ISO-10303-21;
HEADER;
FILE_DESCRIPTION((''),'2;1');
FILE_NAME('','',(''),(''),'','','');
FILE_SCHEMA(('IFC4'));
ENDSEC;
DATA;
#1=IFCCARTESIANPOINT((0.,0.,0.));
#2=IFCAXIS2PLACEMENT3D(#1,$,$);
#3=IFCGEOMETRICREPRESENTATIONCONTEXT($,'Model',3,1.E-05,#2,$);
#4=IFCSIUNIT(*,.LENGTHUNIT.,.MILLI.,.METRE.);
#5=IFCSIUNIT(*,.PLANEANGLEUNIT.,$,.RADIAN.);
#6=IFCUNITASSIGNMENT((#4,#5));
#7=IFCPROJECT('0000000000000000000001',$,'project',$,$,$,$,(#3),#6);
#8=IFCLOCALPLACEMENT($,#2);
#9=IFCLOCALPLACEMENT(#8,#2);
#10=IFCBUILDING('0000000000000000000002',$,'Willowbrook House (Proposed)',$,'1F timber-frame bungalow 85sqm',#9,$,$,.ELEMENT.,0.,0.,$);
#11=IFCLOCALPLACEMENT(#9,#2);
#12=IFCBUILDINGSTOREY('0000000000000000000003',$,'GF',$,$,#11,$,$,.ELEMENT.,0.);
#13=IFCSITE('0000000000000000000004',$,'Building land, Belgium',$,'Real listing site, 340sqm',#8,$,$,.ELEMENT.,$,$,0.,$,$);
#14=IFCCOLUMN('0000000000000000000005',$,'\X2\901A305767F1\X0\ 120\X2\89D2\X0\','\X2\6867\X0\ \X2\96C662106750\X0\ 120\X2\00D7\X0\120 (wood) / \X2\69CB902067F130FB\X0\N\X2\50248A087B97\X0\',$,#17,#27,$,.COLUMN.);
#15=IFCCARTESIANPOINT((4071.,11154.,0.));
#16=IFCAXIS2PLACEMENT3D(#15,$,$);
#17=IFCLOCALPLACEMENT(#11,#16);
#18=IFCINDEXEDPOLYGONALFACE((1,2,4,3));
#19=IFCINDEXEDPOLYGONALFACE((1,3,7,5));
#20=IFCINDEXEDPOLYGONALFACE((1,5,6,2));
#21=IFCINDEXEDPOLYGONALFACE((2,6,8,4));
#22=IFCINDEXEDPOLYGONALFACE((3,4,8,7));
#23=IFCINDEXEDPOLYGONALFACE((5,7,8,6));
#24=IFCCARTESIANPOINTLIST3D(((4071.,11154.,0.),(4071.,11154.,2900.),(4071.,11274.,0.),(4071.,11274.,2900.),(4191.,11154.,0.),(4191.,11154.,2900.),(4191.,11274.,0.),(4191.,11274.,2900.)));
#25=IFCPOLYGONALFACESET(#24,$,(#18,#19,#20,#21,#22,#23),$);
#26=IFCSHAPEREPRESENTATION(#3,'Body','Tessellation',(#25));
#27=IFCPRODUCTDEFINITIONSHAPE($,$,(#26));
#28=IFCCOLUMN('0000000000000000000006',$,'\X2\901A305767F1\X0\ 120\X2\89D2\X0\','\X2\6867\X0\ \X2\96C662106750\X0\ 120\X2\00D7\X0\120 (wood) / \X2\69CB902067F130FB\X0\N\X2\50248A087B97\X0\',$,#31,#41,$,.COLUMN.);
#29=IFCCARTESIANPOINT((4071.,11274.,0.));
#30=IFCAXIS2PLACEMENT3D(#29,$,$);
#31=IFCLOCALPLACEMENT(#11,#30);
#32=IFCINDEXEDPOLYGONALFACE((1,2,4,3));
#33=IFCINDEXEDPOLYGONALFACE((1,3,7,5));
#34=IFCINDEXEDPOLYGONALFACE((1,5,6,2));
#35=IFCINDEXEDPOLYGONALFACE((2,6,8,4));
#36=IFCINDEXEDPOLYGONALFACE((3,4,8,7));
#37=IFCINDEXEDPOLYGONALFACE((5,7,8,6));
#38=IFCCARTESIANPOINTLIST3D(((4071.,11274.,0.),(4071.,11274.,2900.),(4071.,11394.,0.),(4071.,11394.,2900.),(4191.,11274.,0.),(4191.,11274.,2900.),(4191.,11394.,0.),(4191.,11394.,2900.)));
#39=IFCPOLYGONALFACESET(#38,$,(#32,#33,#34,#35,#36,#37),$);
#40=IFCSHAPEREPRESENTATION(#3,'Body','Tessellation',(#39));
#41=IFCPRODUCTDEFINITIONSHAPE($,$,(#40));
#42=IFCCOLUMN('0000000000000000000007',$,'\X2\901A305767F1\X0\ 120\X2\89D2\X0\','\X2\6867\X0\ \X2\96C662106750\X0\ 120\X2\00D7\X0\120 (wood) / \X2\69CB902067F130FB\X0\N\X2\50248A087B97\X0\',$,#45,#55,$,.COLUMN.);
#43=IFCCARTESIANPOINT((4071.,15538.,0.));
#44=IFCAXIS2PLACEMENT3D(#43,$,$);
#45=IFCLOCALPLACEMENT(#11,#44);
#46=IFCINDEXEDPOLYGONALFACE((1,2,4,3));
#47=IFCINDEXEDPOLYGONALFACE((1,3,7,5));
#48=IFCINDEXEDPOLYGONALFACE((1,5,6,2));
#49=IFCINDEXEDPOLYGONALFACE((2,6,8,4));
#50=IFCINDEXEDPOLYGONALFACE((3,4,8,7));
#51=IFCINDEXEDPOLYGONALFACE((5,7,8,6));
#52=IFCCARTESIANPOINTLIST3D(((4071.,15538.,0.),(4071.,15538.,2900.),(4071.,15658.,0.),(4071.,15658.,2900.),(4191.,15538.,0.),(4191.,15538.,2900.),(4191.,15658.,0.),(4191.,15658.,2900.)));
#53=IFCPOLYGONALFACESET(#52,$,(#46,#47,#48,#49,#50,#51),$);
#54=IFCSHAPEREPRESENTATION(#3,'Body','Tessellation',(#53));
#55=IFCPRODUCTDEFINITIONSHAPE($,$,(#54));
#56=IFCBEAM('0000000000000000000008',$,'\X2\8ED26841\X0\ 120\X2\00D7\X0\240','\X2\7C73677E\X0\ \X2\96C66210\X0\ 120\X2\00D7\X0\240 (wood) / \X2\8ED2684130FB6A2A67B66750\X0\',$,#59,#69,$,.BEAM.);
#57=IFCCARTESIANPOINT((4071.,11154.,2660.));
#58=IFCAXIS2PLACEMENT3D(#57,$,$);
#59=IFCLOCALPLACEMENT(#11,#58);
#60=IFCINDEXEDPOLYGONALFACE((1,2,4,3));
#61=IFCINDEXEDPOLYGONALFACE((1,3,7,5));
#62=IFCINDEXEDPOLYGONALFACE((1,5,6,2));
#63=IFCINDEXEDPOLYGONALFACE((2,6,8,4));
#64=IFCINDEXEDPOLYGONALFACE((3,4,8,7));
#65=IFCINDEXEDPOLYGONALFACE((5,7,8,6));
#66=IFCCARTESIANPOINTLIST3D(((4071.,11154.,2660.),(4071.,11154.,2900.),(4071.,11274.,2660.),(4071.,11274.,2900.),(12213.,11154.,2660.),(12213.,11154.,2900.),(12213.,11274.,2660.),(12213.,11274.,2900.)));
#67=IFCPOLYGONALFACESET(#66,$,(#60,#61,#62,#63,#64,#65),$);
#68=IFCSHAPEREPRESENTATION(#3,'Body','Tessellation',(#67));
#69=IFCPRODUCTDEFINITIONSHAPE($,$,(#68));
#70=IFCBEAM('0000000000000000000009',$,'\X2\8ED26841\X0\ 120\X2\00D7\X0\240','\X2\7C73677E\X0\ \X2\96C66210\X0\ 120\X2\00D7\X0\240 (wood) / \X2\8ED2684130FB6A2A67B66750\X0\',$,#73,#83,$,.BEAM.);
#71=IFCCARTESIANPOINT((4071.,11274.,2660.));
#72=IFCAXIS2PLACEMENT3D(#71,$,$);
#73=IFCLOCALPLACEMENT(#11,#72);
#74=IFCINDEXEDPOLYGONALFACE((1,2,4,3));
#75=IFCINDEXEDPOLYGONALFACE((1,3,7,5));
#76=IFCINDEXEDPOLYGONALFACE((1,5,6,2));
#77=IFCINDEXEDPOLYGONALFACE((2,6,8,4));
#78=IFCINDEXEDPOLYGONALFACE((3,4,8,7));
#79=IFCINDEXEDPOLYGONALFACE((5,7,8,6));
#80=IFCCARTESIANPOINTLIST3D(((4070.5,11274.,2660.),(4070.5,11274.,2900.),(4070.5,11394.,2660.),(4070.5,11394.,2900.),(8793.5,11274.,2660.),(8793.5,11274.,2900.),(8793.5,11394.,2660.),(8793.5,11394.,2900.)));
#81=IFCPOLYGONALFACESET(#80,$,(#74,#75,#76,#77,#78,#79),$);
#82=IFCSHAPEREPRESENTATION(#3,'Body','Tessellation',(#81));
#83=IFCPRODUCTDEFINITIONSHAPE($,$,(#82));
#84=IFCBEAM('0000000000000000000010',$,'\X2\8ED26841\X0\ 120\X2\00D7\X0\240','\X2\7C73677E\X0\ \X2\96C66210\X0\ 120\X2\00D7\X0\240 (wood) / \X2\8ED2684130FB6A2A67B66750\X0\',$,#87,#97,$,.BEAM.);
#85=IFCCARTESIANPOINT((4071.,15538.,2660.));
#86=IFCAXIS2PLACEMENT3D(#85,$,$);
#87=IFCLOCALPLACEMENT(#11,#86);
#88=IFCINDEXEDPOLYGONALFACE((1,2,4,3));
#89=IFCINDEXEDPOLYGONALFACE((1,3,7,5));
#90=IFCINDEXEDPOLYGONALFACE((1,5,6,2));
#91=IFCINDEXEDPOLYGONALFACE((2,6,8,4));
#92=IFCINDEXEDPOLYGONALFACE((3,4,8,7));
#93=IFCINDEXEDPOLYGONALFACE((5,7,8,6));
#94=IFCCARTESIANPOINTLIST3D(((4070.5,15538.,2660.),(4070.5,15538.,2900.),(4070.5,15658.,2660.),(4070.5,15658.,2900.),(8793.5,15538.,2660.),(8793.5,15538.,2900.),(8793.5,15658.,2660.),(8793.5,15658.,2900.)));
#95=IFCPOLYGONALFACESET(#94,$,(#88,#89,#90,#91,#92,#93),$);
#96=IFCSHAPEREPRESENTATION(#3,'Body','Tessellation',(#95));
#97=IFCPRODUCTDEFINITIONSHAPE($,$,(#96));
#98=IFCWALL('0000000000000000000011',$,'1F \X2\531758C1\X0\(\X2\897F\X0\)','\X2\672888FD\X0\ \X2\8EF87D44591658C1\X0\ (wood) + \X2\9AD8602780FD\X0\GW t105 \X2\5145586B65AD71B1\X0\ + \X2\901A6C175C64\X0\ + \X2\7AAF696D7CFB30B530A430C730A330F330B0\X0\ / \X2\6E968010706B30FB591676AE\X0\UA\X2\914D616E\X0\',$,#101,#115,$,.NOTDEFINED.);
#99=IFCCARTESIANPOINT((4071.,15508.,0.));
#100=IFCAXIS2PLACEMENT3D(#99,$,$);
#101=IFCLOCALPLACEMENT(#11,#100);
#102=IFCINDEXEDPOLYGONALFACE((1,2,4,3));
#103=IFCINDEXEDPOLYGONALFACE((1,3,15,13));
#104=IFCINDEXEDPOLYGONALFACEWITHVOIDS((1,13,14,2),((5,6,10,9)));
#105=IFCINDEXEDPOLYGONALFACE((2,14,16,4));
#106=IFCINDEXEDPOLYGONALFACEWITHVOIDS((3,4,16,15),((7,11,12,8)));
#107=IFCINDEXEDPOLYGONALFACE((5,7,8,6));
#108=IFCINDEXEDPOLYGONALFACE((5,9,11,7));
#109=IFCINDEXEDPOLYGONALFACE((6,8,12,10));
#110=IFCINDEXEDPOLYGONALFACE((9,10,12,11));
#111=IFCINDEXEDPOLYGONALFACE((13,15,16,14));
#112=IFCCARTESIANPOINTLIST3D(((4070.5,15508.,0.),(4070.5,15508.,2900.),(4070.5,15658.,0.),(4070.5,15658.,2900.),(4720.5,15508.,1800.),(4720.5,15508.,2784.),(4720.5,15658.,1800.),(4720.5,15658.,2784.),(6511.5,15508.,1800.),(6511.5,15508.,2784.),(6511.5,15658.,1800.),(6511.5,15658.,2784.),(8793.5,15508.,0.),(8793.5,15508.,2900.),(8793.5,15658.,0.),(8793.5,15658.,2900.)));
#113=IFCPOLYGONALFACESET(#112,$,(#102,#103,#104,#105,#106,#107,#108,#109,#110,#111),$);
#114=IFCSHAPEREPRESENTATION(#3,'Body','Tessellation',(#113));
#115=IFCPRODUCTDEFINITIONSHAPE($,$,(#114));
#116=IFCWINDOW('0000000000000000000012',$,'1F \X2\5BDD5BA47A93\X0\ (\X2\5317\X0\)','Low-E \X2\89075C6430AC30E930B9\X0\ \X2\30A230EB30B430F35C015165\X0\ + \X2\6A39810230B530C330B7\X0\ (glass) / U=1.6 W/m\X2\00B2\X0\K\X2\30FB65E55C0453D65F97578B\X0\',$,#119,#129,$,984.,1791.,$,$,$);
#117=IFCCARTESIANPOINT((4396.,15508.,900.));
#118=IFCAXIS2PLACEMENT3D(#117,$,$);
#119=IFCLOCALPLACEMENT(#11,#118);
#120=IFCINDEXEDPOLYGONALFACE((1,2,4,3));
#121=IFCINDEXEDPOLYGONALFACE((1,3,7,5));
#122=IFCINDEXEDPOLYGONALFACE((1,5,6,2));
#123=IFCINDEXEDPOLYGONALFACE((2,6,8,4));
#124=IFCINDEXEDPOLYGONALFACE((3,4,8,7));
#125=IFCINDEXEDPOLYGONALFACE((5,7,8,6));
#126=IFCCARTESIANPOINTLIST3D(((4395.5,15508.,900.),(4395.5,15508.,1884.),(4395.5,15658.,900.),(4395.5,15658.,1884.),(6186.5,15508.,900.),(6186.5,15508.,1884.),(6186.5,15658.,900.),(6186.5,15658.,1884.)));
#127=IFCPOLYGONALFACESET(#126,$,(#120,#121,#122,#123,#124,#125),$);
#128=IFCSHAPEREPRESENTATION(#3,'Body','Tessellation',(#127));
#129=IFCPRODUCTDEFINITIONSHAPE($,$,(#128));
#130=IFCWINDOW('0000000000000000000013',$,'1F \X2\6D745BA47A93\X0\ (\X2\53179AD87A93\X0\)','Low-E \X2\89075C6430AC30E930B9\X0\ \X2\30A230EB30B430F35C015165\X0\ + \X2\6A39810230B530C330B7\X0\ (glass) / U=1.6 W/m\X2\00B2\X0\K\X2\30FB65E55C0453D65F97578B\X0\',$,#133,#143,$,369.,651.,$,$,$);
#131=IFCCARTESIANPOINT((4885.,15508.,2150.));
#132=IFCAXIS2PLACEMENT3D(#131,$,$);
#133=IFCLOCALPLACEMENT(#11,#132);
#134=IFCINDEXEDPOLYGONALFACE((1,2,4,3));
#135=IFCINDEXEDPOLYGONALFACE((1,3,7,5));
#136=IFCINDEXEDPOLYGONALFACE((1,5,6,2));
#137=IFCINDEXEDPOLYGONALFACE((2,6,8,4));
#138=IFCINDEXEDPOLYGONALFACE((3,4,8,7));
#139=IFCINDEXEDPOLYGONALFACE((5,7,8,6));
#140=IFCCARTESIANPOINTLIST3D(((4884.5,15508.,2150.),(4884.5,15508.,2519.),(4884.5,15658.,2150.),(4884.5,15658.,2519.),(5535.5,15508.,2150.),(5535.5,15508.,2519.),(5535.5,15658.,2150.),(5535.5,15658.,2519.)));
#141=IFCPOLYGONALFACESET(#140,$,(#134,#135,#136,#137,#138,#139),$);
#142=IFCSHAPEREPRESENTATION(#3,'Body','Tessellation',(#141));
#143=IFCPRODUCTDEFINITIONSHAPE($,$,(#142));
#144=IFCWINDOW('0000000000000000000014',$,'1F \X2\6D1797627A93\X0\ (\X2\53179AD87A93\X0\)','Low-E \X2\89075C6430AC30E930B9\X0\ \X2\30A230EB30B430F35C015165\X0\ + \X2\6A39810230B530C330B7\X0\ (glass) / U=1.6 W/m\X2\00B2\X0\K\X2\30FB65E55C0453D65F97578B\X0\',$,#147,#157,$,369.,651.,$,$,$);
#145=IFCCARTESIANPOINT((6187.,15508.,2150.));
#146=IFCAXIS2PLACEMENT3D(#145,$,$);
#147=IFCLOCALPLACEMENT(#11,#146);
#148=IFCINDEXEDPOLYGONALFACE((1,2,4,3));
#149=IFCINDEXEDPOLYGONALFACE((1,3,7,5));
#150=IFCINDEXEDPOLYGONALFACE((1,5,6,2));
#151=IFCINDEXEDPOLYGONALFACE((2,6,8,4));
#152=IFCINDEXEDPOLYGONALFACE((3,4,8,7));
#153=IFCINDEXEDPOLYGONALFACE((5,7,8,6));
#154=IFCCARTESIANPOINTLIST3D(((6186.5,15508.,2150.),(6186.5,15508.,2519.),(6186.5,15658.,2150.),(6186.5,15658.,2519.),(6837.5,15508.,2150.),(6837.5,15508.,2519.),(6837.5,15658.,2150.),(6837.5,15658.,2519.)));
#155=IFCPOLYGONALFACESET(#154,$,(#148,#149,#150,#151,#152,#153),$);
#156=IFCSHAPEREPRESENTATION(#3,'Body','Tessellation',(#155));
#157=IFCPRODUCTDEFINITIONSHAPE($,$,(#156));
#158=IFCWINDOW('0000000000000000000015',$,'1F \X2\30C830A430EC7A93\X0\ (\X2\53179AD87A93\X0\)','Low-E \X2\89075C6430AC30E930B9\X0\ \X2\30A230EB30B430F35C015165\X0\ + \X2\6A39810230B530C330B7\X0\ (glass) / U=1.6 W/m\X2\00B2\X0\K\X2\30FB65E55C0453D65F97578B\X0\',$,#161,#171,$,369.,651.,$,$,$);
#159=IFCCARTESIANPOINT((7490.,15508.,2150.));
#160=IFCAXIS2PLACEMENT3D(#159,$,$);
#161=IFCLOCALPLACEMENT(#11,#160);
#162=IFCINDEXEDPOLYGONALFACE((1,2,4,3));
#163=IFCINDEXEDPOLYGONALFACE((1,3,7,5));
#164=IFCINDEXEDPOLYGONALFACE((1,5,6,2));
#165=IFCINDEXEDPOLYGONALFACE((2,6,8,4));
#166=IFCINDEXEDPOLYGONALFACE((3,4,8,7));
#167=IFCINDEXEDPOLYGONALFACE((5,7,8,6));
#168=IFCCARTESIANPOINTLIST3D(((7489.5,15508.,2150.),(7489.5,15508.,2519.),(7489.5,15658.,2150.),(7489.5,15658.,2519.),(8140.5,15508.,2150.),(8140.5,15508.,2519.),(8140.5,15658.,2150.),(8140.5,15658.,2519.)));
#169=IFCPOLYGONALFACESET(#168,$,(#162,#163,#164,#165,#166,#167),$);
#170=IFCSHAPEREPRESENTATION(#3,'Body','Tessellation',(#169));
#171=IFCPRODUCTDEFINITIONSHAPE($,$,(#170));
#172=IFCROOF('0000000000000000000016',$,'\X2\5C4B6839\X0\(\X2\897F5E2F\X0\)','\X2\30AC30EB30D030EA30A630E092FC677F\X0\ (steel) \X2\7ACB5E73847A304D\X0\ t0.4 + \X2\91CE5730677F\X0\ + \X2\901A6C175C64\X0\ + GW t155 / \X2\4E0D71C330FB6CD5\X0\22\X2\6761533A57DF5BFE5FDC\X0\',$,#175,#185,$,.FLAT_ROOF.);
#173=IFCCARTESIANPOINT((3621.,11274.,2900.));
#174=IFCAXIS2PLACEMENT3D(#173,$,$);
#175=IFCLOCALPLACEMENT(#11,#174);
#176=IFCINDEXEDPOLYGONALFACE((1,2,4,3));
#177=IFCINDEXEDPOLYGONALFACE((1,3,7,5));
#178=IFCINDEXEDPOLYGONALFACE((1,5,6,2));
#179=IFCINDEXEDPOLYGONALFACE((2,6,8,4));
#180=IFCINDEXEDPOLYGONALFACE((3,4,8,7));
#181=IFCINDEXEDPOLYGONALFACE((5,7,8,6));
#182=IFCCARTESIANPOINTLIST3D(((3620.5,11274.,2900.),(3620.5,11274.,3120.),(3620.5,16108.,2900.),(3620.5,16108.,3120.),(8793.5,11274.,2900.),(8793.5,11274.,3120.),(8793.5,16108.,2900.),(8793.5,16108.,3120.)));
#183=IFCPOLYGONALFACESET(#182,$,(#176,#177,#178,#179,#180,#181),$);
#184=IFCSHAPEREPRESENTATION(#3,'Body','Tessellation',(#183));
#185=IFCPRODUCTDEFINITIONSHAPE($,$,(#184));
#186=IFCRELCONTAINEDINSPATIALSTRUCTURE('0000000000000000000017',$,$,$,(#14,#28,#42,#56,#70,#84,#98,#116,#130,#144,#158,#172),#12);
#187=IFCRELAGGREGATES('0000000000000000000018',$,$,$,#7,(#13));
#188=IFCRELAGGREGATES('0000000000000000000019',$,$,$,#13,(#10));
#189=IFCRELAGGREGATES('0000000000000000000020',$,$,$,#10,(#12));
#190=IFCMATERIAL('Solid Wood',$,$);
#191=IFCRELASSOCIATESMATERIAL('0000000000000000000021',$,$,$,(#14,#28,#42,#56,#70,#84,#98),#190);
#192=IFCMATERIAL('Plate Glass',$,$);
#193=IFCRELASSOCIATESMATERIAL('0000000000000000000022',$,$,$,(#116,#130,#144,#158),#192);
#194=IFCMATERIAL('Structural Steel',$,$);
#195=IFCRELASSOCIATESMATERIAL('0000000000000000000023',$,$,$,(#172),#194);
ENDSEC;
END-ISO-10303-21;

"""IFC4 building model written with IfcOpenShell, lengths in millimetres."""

from ifc_helpers import new_model, si_unit, frame, frame_2d, origin, place, context, project, spatial, rectangle, extrude, material, element, fill, save


model = new_model("IFC4")

# Units and contexts
model_context = context("Model", 3, precision=1e-05, world=origin())
ifc_project = project(units=[si_unit("LENGTHUNIT", "METRE", prefix="MILLI"), si_unit("PLANEANGLEUNIT", "RADIAN")], contexts=[model_context])

# Site, building, storey
site_placement = place(None, origin())
site = spatial("IfcSite", under=ifc_project, at=site_placement, Name="Building land, Belgium", ObjectType="Real listing site, 340sqm", CompositionType="ELEMENT", RefElevation=0.0)
building_placement = place(site_placement, origin())
building = spatial("IfcBuilding", under=site, at=building_placement, Name="Willowbrook House (Proposed)", ObjectType="1F timber-frame bungalow 85sqm", CompositionType="ELEMENT", ElevationOfRefHeight=0.0, ElevationOfTerrain=0.0)
storey_placement = place(building_placement, origin())
storey = spatial("IfcBuildingStorey", under=building, at=storey_placement, Name="GF", CompositionType="ELEMENT", Elevation=0.0)

# Columns
ifc_material_1 = material(Name="Solid Wood")
column_1_placement = place(storey_placement, frame((4071.0, 11154.0, 0.0)))
element("IfcColumn", 1, at=column_1_placement, inside=storey, material=ifc_material_1, Name="通し柱 120角", Description="桧 集成材 120×120 (wood) / 構造柱・N値計算", PredefinedType="COLUMN", context=model_context, shape_type="SweptSolid", body=[
    extrude(rectangle(XDim=120.0, YDim=120.0, at=frame_2d((60.0, 60.0))), frame((4071.0, 11154.0, 0.0)), (0.0, 0.0, 1.0), 2900.0),
])
column_2_placement = place(storey_placement, frame((4071.0, 11274.0, 0.0)))
element("IfcColumn", 2, at=column_2_placement, inside=storey, material=ifc_material_1, Name="通し柱 120角", Description="桧 集成材 120×120 (wood) / 構造柱・N値計算", PredefinedType="COLUMN", context=model_context, shape_type="SweptSolid", body=[
    extrude(rectangle(XDim=120.0, YDim=120.0, at=frame_2d((60.0, 60.0))), frame((4071.0, 11274.0, 0.0)), (0.0, 0.0, 1.0), 2900.0),
])
column_3_placement = place(storey_placement, frame((4071.0, 15538.0, 0.0)))
element("IfcColumn", 3, at=column_3_placement, inside=storey, material=ifc_material_1, Name="通し柱 120角", Description="桧 集成材 120×120 (wood) / 構造柱・N値計算", PredefinedType="COLUMN", context=model_context, shape_type="SweptSolid", body=[
    extrude(rectangle(XDim=120.0, YDim=120.0, at=frame_2d((60.0, 60.0))), frame((4071.0, 15538.0, 0.0)), (0.0, 0.0, 1.0), 2900.0),
])

# Beams
beam_1_placement = place(storey_placement, frame((4071.0, 11154.0, 2660.0)))
element("IfcBeam", 4, at=beam_1_placement, inside=storey, material=ifc_material_1, Name="軒桁 120×240", Description="米松 集成 120×240 (wood) / 軒桁・横架材", PredefinedType="BEAM", context=model_context, shape_type="SweptSolid", body=[
    extrude(rectangle(XDim=8142.0, YDim=120.0, at=frame_2d((4071.0, 60.0))), frame((4071.0, 11154.0, 2660.0)), (0.0, 0.0, 1.0), 240.0),
])
beam_2_placement = place(storey_placement, frame((4071.0, 11274.0, 2660.0)))
element("IfcBeam", 5, at=beam_2_placement, inside=storey, material=ifc_material_1, Name="軒桁 120×240", Description="米松 集成 120×240 (wood) / 軒桁・横架材", PredefinedType="BEAM", context=model_context, shape_type="SweptSolid", body=[
    extrude(rectangle(XDim=4723.0, YDim=120.0, at=frame_2d((2361.0, 60.0))), frame((4071.0, 11274.0, 2660.0)), (0.0, 0.0, 1.0), 240.0),
])
beam_3_placement = place(storey_placement, frame((4071.0, 15538.0, 2660.0)))
element("IfcBeam", 6, at=beam_3_placement, inside=storey, material=ifc_material_1, Name="軒桁 120×240", Description="米松 集成 120×240 (wood) / 軒桁・横架材", PredefinedType="BEAM", context=model_context, shape_type="SweptSolid", body=[
    extrude(rectangle(XDim=4723.0, YDim=120.0, at=frame_2d((2361.0, 60.0))), frame((4071.0, 15538.0, 2660.0)), (0.0, 0.0, 1.0), 240.0),
])

# Wall, openings, windows
wall_1_placement = place(storey_placement, frame((4071.0, 15508.0, 0.0)))
wall_1 = element("IfcWall", 7, at=wall_1_placement, inside=storey, material=ifc_material_1, Name="1F 北壁(西)", Description="木製 軸組外壁 (wood) + 高性能GW t105 充填断熱 + 通気層 + 窯業系サイディング / 準耐火・外皮UA配慮", PredefinedType="NOTDEFINED", context=model_context, shape_type="SweptSolid", body=[
    extrude(rectangle(XDim=4723.0, YDim=150.0, at=frame_2d((2361.0, 75.0))), frame((4071.0, 15508.0, 0.0)), (0.0, 0.0, 1.0), 2900.0),
])
opening_1_placement = place(storey_placement, frame((4396.0, 15508.0, 900.0)))
opening_1 = element("IfcOpeningElement", 8, at=opening_1_placement, cuts=wall_1, PredefinedType="NOTDEFINED", context=model_context, shape_type="SweptSolid", body=[
    extrude(rectangle(XDim=1791.0, YDim=150.0, at=frame_2d((895.0, 75.0))), frame((4396.0, 15508.0, 900.0)), (0.0, 0.0, 1.0), 984.0),
])
opening_2_placement = place(storey_placement, frame((4885.0, 15508.0, 2150.0)))
opening_2 = element("IfcOpeningElement", 9, at=opening_2_placement, cuts=wall_1, PredefinedType="NOTDEFINED", context=model_context, shape_type="SweptSolid", body=[
    extrude(rectangle(XDim=651.0, YDim=150.0, at=frame_2d((325.0, 75.0))), frame((4885.0, 15508.0, 2150.0)), (0.0, 0.0, 1.0), 369.0),
])
opening_3_placement = place(storey_placement, frame((6187.0, 15508.0, 2150.0)))
opening_3 = element("IfcOpeningElement", 10, at=opening_3_placement, cuts=wall_1, PredefinedType="NOTDEFINED", context=model_context, shape_type="SweptSolid", body=[
    extrude(rectangle(XDim=651.0, YDim=150.0, at=frame_2d((325.0, 75.0))), frame((6187.0, 15508.0, 2150.0)), (0.0, 0.0, 1.0), 369.0),
])
opening_4_placement = place(storey_placement, frame((7490.0, 15508.0, 2150.0)))
opening_4 = element("IfcOpeningElement", 11, at=opening_4_placement, cuts=wall_1, PredefinedType="NOTDEFINED", context=model_context, shape_type="SweptSolid", body=[
    extrude(rectangle(XDim=651.0, YDim=150.0, at=frame_2d((325.0, 75.0))), frame((7490.0, 15508.0, 2150.0)), (0.0, 0.0, 1.0), 369.0),
])
ifc_material_2 = material(Name="Plate Glass")
window_1_placement = place(storey_placement, frame((4396.0, 15508.0, 900.0)))
window_1 = element("IfcWindow", 12, at=window_1_placement, inside=storey, material=ifc_material_2, Name="1F 寝室窓 (北)", Description="Low-E 複層ガラス アルゴン封入 + 樹脂サッシ (glass) / U=1.6 W/m²K・日射取得型", OverallHeight=984.0, OverallWidth=1791.0, context=model_context, shape_type="SweptSolid", body=[
    extrude(rectangle(XDim=1791.0, YDim=150.0, at=frame_2d((895.0, 75.0))), frame((4396.0, 15508.0, 900.0)), (0.0, 0.0, 1.0), 984.0),
])
fill(opening_1, window_1)
window_2_placement = place(storey_placement, frame((4885.0, 15508.0, 2150.0)))
window_2 = element("IfcWindow", 13, at=window_2_placement, inside=storey, material=ifc_material_2, Name="1F 浴室窓 (北高窓)", Description="Low-E 複層ガラス アルゴン封入 + 樹脂サッシ (glass) / U=1.6 W/m²K・日射取得型", OverallHeight=369.0, OverallWidth=651.0, context=model_context, shape_type="SweptSolid", body=[
    extrude(rectangle(XDim=651.0, YDim=150.0, at=frame_2d((325.0, 75.0))), frame((4885.0, 15508.0, 2150.0)), (0.0, 0.0, 1.0), 369.0),
])
fill(opening_2, window_2)
window_3_placement = place(storey_placement, frame((6187.0, 15508.0, 2150.0)))
window_3 = element("IfcWindow", 14, at=window_3_placement, inside=storey, material=ifc_material_2, Name="1F 洗面窓 (北高窓)", Description="Low-E 複層ガラス アルゴン封入 + 樹脂サッシ (glass) / U=1.6 W/m²K・日射取得型", OverallHeight=369.0, OverallWidth=651.0, context=model_context, shape_type="SweptSolid", body=[
    extrude(rectangle(XDim=651.0, YDim=150.0, at=frame_2d((325.0, 75.0))), frame((6187.0, 15508.0, 2150.0)), (0.0, 0.0, 1.0), 369.0),
])
fill(opening_3, window_3)
window_4_placement = place(storey_placement, frame((7490.0, 15508.0, 2150.0)))
window_4 = element("IfcWindow", 15, at=window_4_placement, inside=storey, material=ifc_material_2, Name="1F トイレ窓 (北高窓)", Description="Low-E 複層ガラス アルゴン封入 + 樹脂サッシ (glass) / U=1.6 W/m²K・日射取得型", OverallHeight=369.0, OverallWidth=651.0, context=model_context, shape_type="SweptSolid", body=[
    extrude(rectangle(XDim=651.0, YDim=150.0, at=frame_2d((325.0, 75.0))), frame((7490.0, 15508.0, 2150.0)), (0.0, 0.0, 1.0), 369.0),
])
fill(opening_4, window_4)

# Roof
ifc_material_3 = material(Name="Structural Steel")
roof_placement = place(storey_placement, frame((3621.0, 11274.0, 2900.0)))
element("IfcRoof", 16, at=roof_placement, inside=storey, material=ifc_material_3, Name="屋根(西帯)", Description="ガルバリウム鋼板 (steel) 立平葺き t0.4 + 野地板 + 通気層 + GW t155 / 不燃・法22条区域対応", PredefinedType="FLAT_ROOF", context=model_context, shape_type="SweptSolid", body=[
    extrude(rectangle(XDim=5173.0, YDim=4834.0, at=frame_2d((2586.0, 2417.0))), frame((3621.0, 11274.0, 2900.0)), (0.0, 0.0, 1.0), 220.0),
])

save(model, "model.ifc")
